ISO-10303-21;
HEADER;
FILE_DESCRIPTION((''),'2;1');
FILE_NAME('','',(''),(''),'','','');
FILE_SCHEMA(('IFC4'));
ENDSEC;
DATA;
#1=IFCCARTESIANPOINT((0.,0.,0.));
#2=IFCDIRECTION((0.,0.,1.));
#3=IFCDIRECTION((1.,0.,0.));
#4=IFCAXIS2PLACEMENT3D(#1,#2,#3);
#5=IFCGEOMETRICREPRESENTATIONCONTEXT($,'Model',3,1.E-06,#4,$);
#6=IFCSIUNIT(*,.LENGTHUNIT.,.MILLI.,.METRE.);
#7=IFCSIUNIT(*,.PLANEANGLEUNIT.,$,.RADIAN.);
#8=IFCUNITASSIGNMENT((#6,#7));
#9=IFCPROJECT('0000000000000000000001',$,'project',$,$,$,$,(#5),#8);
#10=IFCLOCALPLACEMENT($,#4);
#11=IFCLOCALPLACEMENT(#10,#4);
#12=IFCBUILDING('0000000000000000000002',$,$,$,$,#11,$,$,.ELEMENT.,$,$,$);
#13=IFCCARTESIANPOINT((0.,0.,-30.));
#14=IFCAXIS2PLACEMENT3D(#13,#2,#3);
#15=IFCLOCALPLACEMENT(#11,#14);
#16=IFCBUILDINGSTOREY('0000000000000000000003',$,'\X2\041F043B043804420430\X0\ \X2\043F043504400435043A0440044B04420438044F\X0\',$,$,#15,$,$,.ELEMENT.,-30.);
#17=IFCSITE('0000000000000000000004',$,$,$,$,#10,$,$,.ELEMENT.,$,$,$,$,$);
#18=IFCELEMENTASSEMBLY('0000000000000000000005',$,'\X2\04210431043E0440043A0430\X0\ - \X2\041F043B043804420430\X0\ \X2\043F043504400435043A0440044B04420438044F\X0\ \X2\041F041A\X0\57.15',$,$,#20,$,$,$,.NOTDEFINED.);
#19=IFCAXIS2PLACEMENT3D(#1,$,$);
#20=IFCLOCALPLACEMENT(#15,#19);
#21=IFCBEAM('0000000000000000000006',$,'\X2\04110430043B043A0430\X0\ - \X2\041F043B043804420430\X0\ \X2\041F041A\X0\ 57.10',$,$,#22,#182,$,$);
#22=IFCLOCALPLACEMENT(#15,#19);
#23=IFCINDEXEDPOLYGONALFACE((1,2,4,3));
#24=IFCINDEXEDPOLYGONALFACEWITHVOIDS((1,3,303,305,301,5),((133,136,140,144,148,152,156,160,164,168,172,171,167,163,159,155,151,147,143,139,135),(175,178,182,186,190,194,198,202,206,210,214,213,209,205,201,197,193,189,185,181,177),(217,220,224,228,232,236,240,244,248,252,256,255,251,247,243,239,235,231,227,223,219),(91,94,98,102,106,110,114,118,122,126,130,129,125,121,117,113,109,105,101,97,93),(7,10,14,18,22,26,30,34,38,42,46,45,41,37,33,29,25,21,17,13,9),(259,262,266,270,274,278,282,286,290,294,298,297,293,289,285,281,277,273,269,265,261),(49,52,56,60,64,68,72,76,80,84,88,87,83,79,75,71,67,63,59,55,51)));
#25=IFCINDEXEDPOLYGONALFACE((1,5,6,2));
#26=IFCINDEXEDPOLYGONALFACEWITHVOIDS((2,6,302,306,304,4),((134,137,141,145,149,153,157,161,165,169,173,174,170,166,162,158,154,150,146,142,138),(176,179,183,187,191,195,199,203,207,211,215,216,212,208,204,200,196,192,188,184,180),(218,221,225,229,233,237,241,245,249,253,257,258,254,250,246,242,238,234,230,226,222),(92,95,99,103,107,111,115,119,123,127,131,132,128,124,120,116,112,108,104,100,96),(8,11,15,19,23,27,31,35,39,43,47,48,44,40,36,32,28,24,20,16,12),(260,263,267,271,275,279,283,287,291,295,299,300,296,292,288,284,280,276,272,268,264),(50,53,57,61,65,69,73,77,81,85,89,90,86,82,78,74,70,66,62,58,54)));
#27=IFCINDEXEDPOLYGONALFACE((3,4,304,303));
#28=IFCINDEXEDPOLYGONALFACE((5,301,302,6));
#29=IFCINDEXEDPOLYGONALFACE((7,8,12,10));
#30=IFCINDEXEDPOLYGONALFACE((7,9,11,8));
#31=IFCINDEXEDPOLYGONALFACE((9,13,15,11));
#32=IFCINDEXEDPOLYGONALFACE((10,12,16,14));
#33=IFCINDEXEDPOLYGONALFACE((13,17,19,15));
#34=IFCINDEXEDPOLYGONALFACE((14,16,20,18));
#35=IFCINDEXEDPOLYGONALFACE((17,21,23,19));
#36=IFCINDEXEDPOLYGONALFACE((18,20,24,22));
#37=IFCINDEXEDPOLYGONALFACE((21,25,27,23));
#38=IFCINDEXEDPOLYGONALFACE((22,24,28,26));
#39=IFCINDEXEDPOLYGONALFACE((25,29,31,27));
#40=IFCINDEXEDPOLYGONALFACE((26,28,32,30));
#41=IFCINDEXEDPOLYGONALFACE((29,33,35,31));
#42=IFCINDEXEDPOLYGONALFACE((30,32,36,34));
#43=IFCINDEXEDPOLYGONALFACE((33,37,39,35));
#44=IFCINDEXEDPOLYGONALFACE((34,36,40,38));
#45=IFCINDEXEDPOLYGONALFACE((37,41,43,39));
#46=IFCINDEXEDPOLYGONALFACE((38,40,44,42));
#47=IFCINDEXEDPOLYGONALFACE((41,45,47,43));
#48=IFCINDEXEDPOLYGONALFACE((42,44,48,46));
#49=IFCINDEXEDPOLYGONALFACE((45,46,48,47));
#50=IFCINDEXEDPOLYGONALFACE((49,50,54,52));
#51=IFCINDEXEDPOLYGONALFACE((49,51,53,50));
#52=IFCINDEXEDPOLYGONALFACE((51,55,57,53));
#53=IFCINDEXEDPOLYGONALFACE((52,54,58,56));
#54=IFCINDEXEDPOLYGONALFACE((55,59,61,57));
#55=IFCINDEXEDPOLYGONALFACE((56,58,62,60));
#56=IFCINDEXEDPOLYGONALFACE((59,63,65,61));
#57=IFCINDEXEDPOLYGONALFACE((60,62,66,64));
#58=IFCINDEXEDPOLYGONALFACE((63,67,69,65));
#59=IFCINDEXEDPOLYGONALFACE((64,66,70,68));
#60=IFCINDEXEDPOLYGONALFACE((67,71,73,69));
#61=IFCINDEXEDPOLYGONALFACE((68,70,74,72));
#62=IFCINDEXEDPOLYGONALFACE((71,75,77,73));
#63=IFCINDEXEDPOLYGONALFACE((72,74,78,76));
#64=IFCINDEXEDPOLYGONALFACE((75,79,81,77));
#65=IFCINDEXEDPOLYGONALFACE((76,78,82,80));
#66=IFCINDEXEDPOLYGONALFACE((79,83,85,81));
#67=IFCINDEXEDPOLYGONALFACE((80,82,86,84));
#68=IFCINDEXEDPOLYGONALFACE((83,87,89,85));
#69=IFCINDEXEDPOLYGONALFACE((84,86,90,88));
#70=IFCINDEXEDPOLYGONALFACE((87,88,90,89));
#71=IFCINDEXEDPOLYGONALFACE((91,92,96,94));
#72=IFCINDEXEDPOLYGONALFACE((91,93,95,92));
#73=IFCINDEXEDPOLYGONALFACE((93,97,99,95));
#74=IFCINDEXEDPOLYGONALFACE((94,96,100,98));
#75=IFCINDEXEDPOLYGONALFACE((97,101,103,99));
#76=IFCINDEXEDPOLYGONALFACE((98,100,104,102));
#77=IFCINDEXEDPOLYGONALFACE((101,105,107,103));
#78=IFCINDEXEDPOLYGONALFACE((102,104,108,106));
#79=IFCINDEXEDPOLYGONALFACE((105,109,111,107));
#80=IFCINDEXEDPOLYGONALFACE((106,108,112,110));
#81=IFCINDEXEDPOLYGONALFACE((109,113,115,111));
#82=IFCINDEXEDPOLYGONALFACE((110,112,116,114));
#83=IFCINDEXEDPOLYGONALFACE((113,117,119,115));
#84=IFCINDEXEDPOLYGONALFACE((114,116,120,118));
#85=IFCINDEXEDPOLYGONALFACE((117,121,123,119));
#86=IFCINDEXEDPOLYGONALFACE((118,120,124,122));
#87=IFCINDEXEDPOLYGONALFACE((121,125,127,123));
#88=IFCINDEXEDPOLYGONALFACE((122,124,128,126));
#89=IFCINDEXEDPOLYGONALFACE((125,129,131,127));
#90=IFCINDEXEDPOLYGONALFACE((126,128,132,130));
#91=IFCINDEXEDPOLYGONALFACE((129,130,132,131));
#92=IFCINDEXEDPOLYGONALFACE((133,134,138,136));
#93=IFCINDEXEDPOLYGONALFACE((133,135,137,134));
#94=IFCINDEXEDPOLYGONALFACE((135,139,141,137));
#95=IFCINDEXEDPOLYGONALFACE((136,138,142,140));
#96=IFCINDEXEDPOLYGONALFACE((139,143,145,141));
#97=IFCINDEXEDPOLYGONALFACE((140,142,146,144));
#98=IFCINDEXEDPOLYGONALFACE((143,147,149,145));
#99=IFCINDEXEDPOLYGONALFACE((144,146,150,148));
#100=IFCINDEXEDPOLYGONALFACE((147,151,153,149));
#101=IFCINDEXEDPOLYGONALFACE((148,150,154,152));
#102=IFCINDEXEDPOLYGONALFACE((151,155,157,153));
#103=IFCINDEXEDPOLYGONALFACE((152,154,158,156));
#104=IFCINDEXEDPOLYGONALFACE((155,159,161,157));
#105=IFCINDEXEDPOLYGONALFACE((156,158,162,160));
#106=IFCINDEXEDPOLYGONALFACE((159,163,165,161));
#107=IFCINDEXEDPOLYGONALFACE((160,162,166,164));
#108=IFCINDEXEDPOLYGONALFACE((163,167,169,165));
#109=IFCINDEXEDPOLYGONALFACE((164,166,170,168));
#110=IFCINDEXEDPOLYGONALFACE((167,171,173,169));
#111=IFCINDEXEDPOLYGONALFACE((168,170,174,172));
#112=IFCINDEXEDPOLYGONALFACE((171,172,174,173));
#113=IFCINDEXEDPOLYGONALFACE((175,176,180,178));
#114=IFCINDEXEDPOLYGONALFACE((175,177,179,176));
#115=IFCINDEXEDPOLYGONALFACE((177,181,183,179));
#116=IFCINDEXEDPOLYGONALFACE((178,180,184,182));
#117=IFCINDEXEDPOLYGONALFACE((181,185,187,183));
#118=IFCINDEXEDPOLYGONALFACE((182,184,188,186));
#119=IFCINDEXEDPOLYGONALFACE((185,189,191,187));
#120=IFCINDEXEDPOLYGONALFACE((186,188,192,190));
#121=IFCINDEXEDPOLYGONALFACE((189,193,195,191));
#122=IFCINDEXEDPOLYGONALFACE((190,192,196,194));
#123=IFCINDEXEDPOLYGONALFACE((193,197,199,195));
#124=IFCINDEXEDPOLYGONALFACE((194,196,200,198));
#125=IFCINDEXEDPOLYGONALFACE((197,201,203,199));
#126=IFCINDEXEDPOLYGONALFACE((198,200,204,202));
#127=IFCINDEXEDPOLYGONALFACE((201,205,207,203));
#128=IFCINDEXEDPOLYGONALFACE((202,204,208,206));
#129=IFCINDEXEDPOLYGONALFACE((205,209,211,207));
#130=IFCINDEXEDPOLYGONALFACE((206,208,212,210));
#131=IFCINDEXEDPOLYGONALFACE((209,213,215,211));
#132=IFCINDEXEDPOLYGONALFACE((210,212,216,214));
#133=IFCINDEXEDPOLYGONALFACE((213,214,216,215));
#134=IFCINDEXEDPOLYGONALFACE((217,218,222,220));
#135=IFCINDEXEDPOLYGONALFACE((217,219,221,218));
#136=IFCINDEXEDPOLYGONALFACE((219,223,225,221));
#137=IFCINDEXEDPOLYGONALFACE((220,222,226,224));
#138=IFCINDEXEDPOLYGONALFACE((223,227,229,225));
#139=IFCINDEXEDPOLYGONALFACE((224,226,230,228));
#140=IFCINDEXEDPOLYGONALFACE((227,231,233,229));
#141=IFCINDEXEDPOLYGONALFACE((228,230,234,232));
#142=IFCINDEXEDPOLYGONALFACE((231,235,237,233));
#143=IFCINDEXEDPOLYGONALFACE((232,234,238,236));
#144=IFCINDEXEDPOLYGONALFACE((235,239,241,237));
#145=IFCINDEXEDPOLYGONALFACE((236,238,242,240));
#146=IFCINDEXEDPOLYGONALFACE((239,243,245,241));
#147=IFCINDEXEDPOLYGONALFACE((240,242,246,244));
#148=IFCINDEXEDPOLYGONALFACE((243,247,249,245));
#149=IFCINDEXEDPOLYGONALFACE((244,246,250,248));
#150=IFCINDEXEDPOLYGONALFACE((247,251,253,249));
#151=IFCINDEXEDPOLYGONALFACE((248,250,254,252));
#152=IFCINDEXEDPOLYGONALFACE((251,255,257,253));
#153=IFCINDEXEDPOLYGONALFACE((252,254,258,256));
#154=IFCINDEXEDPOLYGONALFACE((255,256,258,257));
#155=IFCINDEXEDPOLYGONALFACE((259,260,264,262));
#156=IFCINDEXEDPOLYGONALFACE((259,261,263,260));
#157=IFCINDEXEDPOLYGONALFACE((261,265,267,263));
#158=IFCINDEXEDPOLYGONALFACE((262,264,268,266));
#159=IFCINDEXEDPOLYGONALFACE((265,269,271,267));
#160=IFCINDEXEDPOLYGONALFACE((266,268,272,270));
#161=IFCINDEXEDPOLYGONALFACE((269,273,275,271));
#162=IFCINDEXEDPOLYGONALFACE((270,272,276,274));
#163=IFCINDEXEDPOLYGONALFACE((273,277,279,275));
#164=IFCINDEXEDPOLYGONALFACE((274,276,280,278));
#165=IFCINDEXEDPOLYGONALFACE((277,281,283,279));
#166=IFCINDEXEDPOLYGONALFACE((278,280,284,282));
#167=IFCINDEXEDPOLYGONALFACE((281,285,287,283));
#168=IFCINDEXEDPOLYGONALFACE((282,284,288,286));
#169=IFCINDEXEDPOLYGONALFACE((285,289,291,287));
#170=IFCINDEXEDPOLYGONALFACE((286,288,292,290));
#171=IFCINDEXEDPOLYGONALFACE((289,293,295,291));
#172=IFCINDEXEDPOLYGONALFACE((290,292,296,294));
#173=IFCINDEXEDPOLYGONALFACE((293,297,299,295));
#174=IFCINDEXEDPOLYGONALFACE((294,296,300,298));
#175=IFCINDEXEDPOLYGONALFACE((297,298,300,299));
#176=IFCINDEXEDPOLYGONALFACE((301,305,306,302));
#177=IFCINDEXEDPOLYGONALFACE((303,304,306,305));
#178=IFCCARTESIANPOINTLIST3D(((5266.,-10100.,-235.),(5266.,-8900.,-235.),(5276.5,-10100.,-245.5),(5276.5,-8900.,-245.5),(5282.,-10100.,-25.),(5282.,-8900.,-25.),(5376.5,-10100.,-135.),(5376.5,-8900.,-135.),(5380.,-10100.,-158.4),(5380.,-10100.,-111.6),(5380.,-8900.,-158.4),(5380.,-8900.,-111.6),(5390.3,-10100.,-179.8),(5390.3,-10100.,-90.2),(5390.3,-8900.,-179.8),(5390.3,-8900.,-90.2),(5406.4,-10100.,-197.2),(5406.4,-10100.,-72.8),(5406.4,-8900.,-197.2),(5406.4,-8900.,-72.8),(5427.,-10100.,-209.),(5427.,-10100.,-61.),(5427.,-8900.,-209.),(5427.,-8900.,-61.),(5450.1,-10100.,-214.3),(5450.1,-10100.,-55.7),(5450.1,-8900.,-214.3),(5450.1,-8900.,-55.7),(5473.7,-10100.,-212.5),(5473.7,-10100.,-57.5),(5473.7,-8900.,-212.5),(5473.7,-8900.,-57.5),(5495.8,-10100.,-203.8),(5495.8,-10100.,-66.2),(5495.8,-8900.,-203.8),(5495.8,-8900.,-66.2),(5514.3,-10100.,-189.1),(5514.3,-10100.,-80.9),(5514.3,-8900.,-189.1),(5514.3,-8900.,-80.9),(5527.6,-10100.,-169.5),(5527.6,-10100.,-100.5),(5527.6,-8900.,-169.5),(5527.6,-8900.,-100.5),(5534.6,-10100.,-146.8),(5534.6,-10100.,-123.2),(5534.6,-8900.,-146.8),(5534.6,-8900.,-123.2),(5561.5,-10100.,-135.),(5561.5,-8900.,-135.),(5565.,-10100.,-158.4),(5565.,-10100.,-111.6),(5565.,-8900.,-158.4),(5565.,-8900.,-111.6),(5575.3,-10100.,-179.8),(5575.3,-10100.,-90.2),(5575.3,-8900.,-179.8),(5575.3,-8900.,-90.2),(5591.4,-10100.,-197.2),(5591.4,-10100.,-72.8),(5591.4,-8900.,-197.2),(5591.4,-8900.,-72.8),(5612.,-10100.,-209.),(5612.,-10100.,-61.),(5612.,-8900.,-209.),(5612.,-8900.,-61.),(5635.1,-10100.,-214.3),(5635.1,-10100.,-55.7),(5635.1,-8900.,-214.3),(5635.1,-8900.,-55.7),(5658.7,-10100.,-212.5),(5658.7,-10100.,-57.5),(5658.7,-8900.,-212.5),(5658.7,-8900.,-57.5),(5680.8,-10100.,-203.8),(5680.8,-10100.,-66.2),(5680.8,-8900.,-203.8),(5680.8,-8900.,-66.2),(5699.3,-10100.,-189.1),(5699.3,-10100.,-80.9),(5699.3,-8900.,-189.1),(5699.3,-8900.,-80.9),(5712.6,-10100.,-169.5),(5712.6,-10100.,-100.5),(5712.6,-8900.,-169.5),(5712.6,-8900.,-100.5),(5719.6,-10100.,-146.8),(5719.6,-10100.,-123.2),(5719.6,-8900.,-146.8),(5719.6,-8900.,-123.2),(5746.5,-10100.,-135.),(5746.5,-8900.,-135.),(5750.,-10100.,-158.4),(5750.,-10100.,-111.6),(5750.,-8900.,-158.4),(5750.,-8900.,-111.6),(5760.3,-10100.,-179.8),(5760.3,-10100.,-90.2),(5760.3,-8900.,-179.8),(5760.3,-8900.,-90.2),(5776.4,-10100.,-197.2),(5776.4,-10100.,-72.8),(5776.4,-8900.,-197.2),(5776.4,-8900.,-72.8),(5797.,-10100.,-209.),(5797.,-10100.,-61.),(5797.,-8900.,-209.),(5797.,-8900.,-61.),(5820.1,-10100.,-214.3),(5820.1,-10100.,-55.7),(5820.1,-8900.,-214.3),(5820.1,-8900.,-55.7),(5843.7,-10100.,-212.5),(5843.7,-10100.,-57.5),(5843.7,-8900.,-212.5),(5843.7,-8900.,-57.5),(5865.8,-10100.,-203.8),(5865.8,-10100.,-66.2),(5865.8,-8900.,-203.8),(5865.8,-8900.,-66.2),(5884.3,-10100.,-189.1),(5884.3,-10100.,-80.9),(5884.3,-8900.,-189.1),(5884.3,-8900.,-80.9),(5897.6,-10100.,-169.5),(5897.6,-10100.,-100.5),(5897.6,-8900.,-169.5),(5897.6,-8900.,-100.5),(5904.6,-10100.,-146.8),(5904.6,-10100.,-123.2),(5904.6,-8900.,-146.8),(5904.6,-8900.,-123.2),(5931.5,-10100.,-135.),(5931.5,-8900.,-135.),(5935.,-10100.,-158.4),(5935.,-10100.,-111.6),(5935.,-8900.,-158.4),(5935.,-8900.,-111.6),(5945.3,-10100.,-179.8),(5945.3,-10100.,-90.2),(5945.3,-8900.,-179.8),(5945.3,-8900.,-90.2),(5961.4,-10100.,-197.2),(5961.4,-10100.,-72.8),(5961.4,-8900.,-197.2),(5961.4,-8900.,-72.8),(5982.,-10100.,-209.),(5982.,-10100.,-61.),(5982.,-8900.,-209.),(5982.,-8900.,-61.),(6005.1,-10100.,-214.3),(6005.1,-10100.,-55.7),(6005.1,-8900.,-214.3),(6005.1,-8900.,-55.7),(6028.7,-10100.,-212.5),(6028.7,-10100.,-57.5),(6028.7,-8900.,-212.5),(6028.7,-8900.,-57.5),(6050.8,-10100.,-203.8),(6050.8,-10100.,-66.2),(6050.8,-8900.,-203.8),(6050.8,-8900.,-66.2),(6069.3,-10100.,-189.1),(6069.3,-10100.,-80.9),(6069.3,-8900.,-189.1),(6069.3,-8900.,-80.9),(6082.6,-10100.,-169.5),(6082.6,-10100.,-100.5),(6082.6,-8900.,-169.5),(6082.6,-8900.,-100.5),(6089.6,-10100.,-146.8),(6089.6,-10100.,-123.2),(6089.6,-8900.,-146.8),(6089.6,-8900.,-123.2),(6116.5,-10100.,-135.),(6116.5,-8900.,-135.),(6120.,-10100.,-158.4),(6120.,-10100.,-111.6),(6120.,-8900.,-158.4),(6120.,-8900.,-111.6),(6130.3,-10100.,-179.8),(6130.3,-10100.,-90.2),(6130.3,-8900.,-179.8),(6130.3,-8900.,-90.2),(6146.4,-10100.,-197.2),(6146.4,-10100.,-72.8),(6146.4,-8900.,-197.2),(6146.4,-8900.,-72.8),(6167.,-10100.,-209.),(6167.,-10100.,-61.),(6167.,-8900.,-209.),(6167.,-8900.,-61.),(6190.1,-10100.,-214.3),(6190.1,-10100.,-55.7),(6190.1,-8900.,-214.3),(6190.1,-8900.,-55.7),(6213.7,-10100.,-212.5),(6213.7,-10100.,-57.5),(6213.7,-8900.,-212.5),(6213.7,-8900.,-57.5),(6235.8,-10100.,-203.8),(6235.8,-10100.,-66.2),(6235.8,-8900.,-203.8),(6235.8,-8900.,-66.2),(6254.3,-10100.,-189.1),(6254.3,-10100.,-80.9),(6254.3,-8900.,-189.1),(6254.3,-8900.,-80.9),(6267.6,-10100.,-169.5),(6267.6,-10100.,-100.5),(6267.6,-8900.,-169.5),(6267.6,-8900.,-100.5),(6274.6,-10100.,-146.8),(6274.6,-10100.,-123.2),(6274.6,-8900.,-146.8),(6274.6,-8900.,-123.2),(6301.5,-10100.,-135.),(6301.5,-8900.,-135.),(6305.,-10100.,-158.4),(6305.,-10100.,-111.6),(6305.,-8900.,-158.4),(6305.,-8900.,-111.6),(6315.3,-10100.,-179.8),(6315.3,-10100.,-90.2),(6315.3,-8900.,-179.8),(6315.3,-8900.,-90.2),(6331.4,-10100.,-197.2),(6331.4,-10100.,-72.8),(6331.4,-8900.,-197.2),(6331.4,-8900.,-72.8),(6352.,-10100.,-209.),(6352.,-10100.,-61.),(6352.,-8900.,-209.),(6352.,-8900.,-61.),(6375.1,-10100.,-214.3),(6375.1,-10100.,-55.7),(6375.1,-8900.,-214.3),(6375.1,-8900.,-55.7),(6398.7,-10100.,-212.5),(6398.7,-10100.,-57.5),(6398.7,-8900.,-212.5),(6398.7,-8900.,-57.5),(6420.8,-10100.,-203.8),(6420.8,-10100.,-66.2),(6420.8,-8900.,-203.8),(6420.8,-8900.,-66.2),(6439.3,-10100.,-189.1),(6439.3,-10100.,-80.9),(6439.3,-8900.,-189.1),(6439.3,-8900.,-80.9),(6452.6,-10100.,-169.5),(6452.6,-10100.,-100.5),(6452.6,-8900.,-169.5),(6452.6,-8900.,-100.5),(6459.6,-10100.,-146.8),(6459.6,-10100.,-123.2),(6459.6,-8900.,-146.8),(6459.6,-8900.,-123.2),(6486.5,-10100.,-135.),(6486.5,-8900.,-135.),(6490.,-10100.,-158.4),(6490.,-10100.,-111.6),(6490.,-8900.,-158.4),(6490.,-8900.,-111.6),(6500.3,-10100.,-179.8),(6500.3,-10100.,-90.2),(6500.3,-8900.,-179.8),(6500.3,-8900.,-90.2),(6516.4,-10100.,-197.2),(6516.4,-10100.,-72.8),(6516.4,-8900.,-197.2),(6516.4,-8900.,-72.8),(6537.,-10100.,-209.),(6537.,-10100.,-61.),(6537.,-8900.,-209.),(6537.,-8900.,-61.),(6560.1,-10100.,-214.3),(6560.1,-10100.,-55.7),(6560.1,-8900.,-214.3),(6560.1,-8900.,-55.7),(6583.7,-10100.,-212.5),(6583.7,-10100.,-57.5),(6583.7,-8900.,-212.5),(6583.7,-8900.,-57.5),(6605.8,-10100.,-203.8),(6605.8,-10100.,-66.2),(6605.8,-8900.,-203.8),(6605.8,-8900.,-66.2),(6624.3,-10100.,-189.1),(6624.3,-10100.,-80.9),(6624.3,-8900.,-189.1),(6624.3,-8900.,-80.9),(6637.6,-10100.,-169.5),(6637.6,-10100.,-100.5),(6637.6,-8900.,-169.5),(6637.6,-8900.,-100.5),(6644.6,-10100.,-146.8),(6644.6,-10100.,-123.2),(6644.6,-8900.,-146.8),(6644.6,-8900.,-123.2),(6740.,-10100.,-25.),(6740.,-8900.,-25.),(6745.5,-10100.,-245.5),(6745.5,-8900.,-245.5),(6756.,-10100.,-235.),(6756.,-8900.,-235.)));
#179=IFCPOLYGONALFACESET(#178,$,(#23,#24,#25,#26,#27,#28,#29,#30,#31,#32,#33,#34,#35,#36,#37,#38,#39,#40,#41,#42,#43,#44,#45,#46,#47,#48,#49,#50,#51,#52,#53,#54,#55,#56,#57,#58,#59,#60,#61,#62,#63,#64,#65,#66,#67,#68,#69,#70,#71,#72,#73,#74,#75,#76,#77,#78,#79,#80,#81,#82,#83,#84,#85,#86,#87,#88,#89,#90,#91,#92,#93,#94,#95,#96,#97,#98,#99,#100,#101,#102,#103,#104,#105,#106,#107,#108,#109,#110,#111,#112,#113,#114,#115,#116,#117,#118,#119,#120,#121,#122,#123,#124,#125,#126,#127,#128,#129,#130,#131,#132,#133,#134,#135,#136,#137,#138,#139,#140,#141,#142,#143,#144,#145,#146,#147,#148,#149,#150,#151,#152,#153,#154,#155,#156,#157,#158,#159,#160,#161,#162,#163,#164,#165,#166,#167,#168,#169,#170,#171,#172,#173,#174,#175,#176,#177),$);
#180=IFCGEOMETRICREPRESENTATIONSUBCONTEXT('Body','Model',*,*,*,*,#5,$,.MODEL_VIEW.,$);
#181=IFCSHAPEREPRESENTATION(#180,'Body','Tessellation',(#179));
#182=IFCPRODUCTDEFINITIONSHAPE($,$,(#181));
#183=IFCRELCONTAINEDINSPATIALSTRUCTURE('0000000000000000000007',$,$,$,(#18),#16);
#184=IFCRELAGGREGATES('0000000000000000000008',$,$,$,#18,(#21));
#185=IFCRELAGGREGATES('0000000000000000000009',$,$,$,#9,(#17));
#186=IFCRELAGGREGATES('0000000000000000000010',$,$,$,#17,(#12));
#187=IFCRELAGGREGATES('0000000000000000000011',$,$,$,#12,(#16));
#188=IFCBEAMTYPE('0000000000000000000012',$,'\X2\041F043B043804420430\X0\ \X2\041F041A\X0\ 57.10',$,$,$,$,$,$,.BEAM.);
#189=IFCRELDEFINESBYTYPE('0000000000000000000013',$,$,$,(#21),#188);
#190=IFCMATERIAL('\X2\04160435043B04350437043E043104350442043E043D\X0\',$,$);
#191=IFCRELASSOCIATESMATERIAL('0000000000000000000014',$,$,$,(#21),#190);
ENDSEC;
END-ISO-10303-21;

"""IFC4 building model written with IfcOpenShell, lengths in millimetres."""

from ifc_helpers import new_model, si_unit, frame, frame_2d, origin_with_axes, place, context, subcontext, project, spatial, line, indexed_curve, circle_curve, outline, extrude, material, type_object, element, aggregate, save


model = new_model("IFC4")

# Units and contexts
model_context = context("Model", 3, precision=1e-06, world=origin_with_axes())
body_context = subcontext(model_context, "Body", "Model", "MODEL_VIEW")
ifc_project = project(units=[si_unit("LENGTHUNIT", "METRE", prefix="MILLI"), si_unit("PLANEANGLEUNIT", "RADIAN")], contexts=[model_context])

# Site, building, storey
site_placement = place(None, origin_with_axes())
site = spatial("IfcSite", under=ifc_project, at=site_placement, CompositionType="ELEMENT")
building_placement = place(site_placement, origin_with_axes())
building = spatial("IfcBuilding", under=site, at=building_placement, CompositionType="ELEMENT")
storey_placement = place(building_placement, frame((0.0, 0.0, -30.0), z_axis=(0.0, 0.0, 1.0), x_axis=(1.0, 0.0, 0.0)))
storey = spatial("IfcBuildingStorey", under=building, at=storey_placement, Name="Плита перекрытия", CompositionType="ELEMENT", Elevation=-30.0)

# Element assembly, beam
assembly_1_placement = place(storey_placement, frame((6011.0, -9650.0, -25.0), z_axis=(0.0, 0.0, 1.0), x_axis=(1.0, 0.0, 0.0)))
assembly_1 = element("IfcElementAssembly", 1, at=assembly_1_placement, inside=storey, Name="Сборка - Плита перекрытия ПК57.15", PredefinedType="NOTDEFINED")
ifc_material_1 = material(Name="Железобетон")
beam_type_1 = type_object("IfcBeamType", Name="Плита ПК 57.10", PredefinedType="BEAM")
beam_1_placement = place(assembly_1_placement, frame((0.0, 750.0, 0.0), z_axis=(0.0, 1.0, 0.0), x_axis=(-1.0, 0.0, 0.0)))
beam_1 = element("IfcBeam", 2, at=beam_1_placement, type_object=beam_type_1, material=ifc_material_1, Name="Балка - Плита ПК 57.10", context=body_context, shape_type="SweptSolid", body=[
    extrude(outline(indexed_curve([(-729.0, 0.0), (-745.0, -210.0), (-734.5, -220.5), (734.5, -220.5), (745.0, -210.0), (729.0, 0.0)], segments=[line(1, 2), line(2, 3), line(3, 4), line(4, 5), line(5, 6), line(6, 1)]), holes=[circle_curve(frame_2d((555.0, -110.0), x_axis=(1.0, 0.0)), 79.5), circle_curve(frame_2d((370.0, -110.0), x_axis=(1.0, 0.0)), 79.5), circle_curve(frame_2d((185.0, -110.0), x_axis=(1.0, 0.0)), 79.5), circle_curve(frame_2d((-555.0, -110.0), x_axis=(1.0, 0.0)), 79.5), circle_curve(frame_2d((-370.0, -110.0), x_axis=(1.0, 0.0)), 79.5), circle_curve(frame_2d((-185.0, -110.0), x_axis=(1.0, 0.0)), 79.5), circle_curve(frame_2d((0.0, -110.0), x_axis=(1.0, 0.0)), 79.5)]), origin_with_axes(), (0.0, 0.0, -1.0), 1200.0),
])
aggregate(assembly_1, [beam_1])

save(model, "model.ifc")
